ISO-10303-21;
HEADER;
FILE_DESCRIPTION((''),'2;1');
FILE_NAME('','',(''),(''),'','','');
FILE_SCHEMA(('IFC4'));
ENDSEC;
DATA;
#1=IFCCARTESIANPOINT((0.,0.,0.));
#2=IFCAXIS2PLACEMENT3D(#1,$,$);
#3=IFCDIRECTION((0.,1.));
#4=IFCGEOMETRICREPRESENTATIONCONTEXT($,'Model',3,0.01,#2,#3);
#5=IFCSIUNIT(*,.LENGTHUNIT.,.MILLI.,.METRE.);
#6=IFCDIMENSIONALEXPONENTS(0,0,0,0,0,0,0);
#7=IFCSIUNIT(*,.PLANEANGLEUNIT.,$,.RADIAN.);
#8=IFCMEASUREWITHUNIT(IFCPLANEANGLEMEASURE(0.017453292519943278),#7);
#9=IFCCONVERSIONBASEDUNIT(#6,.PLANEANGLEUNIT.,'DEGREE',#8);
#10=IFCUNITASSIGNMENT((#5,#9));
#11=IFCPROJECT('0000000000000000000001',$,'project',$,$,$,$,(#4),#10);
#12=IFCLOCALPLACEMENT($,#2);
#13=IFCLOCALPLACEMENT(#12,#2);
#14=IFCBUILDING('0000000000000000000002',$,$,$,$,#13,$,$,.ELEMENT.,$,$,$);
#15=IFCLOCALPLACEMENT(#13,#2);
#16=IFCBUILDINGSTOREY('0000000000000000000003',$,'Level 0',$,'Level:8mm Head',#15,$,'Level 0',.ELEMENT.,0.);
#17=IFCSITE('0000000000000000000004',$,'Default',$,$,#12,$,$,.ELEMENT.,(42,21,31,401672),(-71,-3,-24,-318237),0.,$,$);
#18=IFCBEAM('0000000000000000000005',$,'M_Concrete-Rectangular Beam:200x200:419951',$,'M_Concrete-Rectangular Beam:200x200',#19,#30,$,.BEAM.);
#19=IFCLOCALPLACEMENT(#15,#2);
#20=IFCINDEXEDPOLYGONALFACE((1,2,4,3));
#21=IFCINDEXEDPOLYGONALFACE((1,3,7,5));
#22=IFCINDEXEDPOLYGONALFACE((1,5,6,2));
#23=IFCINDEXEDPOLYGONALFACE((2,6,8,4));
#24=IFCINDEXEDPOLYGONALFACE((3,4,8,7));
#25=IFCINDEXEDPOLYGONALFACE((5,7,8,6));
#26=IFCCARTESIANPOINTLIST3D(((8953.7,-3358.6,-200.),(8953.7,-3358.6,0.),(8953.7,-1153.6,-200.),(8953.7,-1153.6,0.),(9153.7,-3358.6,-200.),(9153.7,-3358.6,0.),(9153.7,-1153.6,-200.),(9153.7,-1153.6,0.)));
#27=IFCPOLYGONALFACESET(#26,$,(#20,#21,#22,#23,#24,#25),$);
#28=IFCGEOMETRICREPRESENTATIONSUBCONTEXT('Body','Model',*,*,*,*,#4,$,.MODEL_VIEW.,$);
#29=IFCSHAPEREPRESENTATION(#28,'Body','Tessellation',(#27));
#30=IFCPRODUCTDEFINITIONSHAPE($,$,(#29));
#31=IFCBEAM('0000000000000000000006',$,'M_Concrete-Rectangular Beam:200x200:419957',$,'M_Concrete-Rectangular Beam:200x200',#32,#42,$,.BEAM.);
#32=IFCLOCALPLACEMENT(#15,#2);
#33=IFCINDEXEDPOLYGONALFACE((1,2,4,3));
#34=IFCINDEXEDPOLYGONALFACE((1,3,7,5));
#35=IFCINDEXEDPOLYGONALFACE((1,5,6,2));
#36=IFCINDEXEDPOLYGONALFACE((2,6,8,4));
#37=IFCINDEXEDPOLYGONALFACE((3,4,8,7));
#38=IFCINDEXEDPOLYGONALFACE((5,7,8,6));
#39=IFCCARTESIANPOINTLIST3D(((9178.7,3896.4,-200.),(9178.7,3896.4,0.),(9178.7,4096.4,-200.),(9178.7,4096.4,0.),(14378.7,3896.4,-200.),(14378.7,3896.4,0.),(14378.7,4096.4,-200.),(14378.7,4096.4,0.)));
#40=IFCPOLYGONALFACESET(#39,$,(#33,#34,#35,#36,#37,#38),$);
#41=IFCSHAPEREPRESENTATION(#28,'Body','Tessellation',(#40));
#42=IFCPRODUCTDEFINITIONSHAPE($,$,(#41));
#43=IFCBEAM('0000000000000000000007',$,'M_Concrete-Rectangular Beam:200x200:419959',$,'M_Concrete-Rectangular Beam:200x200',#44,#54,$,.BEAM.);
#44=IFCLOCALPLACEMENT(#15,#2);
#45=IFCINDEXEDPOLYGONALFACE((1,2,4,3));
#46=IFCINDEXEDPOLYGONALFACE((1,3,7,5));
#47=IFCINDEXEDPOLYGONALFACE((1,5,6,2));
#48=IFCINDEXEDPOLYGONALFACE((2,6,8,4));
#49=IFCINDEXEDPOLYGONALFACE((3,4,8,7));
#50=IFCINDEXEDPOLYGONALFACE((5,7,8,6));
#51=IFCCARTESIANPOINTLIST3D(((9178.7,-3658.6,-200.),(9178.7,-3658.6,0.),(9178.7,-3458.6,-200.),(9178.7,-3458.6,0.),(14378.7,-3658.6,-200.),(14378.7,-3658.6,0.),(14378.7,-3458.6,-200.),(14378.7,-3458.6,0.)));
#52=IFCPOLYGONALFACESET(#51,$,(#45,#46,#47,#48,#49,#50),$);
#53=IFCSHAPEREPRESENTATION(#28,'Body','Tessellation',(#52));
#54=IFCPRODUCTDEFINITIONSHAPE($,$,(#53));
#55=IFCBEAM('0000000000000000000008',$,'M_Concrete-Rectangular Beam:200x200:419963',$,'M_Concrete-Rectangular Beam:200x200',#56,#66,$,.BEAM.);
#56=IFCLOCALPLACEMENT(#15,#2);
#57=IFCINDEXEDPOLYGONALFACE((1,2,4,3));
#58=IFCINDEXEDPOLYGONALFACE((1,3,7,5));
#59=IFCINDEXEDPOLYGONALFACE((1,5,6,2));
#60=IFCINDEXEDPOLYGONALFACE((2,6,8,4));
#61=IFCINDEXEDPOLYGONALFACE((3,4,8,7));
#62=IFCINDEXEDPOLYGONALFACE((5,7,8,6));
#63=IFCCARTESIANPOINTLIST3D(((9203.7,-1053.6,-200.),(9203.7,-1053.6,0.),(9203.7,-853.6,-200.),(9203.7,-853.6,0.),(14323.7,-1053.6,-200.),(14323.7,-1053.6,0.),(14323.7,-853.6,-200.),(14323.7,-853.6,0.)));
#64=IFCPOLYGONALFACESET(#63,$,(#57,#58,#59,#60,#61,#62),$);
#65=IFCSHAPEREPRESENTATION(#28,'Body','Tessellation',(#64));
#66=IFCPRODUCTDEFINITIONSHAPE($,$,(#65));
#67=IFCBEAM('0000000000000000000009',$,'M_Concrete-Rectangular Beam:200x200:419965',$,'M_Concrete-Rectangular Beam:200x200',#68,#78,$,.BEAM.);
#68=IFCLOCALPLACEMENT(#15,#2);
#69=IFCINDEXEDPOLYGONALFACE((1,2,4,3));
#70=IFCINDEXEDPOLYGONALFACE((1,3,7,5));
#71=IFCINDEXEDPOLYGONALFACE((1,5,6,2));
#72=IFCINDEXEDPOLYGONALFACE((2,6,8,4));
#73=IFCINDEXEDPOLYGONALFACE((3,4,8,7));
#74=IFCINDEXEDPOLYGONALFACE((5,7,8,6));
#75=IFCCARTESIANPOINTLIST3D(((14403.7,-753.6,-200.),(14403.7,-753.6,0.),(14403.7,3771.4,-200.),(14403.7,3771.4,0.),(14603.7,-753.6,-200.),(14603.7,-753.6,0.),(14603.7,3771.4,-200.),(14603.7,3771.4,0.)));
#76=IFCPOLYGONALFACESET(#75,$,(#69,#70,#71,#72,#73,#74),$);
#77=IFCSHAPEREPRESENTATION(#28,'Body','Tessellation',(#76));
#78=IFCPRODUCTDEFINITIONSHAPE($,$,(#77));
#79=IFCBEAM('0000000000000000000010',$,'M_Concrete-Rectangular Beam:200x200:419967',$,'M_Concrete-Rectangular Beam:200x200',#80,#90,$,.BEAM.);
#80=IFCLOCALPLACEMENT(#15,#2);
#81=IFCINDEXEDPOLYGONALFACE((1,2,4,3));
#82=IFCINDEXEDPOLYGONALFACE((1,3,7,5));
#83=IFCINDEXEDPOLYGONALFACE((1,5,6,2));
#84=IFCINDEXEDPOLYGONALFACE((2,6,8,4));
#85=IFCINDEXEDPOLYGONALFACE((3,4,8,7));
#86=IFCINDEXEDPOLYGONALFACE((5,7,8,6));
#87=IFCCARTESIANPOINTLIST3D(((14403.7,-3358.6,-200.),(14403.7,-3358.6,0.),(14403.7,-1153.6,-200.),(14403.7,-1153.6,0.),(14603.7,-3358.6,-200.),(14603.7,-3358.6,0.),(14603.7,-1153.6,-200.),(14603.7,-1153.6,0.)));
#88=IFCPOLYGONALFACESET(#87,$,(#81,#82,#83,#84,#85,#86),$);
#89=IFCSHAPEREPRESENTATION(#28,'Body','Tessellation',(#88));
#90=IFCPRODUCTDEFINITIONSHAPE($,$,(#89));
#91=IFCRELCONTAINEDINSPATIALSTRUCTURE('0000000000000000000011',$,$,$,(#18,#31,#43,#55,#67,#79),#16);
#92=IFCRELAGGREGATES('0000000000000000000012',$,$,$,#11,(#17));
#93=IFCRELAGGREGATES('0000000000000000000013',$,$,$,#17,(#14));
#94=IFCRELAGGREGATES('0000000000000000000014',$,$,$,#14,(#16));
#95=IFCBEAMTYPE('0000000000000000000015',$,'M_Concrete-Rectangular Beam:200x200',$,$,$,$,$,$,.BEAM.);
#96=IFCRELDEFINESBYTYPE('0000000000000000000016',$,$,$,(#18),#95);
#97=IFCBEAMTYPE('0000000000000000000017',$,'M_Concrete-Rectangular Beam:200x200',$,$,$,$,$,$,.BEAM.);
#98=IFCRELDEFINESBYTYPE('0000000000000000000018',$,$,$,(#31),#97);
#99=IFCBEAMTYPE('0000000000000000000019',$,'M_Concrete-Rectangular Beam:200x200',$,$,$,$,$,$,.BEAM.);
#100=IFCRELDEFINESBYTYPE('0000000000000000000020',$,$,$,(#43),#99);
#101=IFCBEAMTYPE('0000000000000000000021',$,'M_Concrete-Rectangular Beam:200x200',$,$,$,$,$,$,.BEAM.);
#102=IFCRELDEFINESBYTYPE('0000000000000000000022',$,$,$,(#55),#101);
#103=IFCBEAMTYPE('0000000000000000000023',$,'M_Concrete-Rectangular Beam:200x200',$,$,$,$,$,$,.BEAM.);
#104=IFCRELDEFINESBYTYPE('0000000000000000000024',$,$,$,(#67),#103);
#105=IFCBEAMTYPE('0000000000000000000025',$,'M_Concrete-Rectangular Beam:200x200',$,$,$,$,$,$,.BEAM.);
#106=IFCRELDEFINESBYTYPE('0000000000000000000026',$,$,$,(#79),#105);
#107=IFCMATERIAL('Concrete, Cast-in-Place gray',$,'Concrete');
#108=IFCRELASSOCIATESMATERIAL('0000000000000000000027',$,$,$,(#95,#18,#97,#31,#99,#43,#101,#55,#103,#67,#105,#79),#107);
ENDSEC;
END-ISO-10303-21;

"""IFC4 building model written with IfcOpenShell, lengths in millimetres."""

from ifc_helpers import new_model, entity, si_unit, converted_unit, direction, frame, origin, place, context, subcontext, project, spatial, indexed_curve, outline, extrude, source, transform, mapped, material, type_object, type_shapes, element, save


model = new_model("IFC4")

# Units and contexts
model_context = context("Model", 3, precision=0.01, world=origin(), true_north=direction((0.0, 1.0)))
body_context = subcontext(model_context, "Body", "Model", "MODEL_VIEW")
ifc_project = project(units=[si_unit("LENGTHUNIT", "METRE", prefix="MILLI"), converted_unit("PLANEANGLEUNIT", "DEGREE", entity("IfcPlaneAngleMeasure", 0.017453292519943278), si_unit("PLANEANGLEUNIT", "RADIAN"), dimensions=[0, 0, 0, 0, 0, 0, 0])], contexts=[model_context])

# Site, building, storey
site_placement = place(None, origin())
site = spatial("IfcSite", under=ifc_project, at=site_placement, Name="Default", CompositionType="ELEMENT", RefLatitude=(42, 21, 31, 401672), RefLongitude=(-71, -3, -24, -318237), RefElevation=0.0)
building_placement = place(site_placement, origin())
building = spatial("IfcBuilding", under=site, at=building_placement, CompositionType="ELEMENT")
storey_placement = place(building_placement, origin())
storey = spatial("IfcBuildingStorey", under=building, at=storey_placement, Name="Level 0", ObjectType="Level:8mm Head", LongName="Level 0", CompositionType="ELEMENT", Elevation=0.0)

# Beams
ifc_material = material(Name="Concrete, Cast-in-Place gray", Category="Concrete")
beam_type_1 = type_object("IfcBeamType", Name="M_Concrete-Rectangular Beam:200x200", PredefinedType="BEAM", material=ifc_material)
shared_shape_1 = source(origin(), body_context, "Body", "SweptSolid", [
    extrude(outline(indexed_curve([(-100.0, -100.0), (100.0, -100.0), (100.0, 100.0), (-100.0, 100.0), (-100.0, -100.0)], self_intersect=False)), frame((9053.7, -1153.6, -100.0), z_axis=(0.0, -1.0, 0.0), x_axis=(-1.0, 0.0, 0.0)), (0.0, 0.0, 1.0), 2205.0),
])
type_shapes(beam_type_1, [shared_shape_1])
beam_1_placement = place(storey_placement, origin())
element("IfcBeam", 1, at=beam_1_placement, inside=storey, type_object=beam_type_1, material=ifc_material, Name="M_Concrete-Rectangular Beam:200x200:419951", ObjectType="M_Concrete-Rectangular Beam:200x200", PredefinedType="BEAM", context=body_context, shape_type="MappedRepresentation", body=[
    mapped(shared_shape_1, transform((0.0, 0.0, 0.0), scale=1.0)),
])
beam_type_2 = type_object("IfcBeamType", Name="M_Concrete-Rectangular Beam:200x200", PredefinedType="BEAM", material=ifc_material)
shared_shape_2 = source(origin(), body_context, "Body", "SweptSolid", [
    extrude(outline(indexed_curve([(-100.0, -100.0), (100.0, -100.0), (100.0, 100.0), (-100.0, 100.0), (-100.0, -100.0)], self_intersect=False)), frame((9178.7, 3996.4, -100.0), z_axis=(1.0, 0.0, 0.0), x_axis=(0.0, 0.0, -1.0)), (0.0, 0.0, 1.0), 5200.0),
])
type_shapes(beam_type_2, [shared_shape_2])
beam_2_placement = place(storey_placement, origin())
element("IfcBeam", 2, at=beam_2_placement, inside=storey, type_object=beam_type_2, material=ifc_material, Name="M_Concrete-Rectangular Beam:200x200:419957", ObjectType="M_Concrete-Rectangular Beam:200x200", PredefinedType="BEAM", context=body_context, shape_type="MappedRepresentation", body=[
    mapped(shared_shape_2, transform((0.0, 0.0, 0.0), scale=1.0)),
])
beam_type_3 = type_object("IfcBeamType", Name="M_Concrete-Rectangular Beam:200x200", PredefinedType="BEAM", material=ifc_material)
shared_shape_3 = source(origin(), body_context, "Body", "SweptSolid", [
    extrude(outline(indexed_curve([(-100.0, -100.0), (100.0, -100.0), (100.0, 100.0), (-100.0, 100.0), (-100.0, -100.0)], self_intersect=False)), frame((9178.7, -3558.6, -100.0), z_axis=(1.0, 0.0, 0.0), x_axis=(0.0, 0.0, -1.0)), (0.0, 0.0, 1.0), 5200.0),
])
type_shapes(beam_type_3, [shared_shape_3])
beam_3_placement = place(storey_placement, origin())
element("IfcBeam", 3, at=beam_3_placement, inside=storey, type_object=beam_type_3, material=ifc_material, Name="M_Concrete-Rectangular Beam:200x200:419959", ObjectType="M_Concrete-Rectangular Beam:200x200", PredefinedType="BEAM", context=body_context, shape_type="MappedRepresentation", body=[
    mapped(shared_shape_3, transform((0.0, 0.0, 0.0), scale=1.0)),
])
beam_type_4 = type_object("IfcBeamType", Name="M_Concrete-Rectangular Beam:200x200", PredefinedType="BEAM", material=ifc_material)
shared_shape_4 = source(origin(), body_context, "Body", "SweptSolid", [
    extrude(outline(indexed_curve([(-100.0, -100.0), (100.0, -100.0), (100.0, 100.0), (-100.0, 100.0), (-100.0, -100.0)], self_intersect=False)), frame((9203.7, -953.6, -100.0), z_axis=(1.0, 0.0, 0.0), x_axis=(0.0, 0.0, -1.0)), (0.0, 0.0, 1.0), 5120.0),
])
type_shapes(beam_type_4, [shared_shape_4])
beam_4_placement = place(storey_placement, origin())
element("IfcBeam", 4, at=beam_4_placement, inside=storey, type_object=beam_type_4, material=ifc_material, Name="M_Concrete-Rectangular Beam:200x200:419963", ObjectType="M_Concrete-Rectangular Beam:200x200", PredefinedType="BEAM", context=body_context, shape_type="MappedRepresentation", body=[
    mapped(shared_shape_4, transform((0.0, 0.0, 0.0), scale=1.0)),
])
beam_type_5 = type_object("IfcBeamType", Name="M_Concrete-Rectangular Beam:200x200", PredefinedType="BEAM", material=ifc_material)
shared_shape_5 = source(origin(), body_context, "Body", "SweptSolid", [
    extrude(outline(indexed_curve([(-100.0, -100.0), (100.0, -100.0), (100.0, 100.0), (-100.0, 100.0), (-100.0, -100.0)], self_intersect=False)), frame((14503.7, 3771.4, -100.0), z_axis=(0.0, -1.0, 0.0), x_axis=(-1.0, 0.0, 0.0)), (0.0, 0.0, 1.0), 4525.0),
])
type_shapes(beam_type_5, [shared_shape_5])
beam_5_placement = place(storey_placement, origin())
element("IfcBeam", 5, at=beam_5_placement, inside=storey, type_object=beam_type_5, material=ifc_material, Name="M_Concrete-Rectangular Beam:200x200:419965", ObjectType="M_Concrete-Rectangular Beam:200x200", PredefinedType="BEAM", context=body_context, shape_type="MappedRepresentation", body=[
    mapped(shared_shape_5, transform((0.0, 0.0, 0.0), scale=1.0)),
])
beam_type_6 = type_object("IfcBeamType", Name="M_Concrete-Rectangular Beam:200x200", PredefinedType="BEAM", material=ifc_material)
shared_shape_6 = source(origin(), body_context, "Body", "SweptSolid", [
    extrude(outline(indexed_curve([(-100.0, -100.0), (100.0, -100.0), (100.0, 100.0), (-100.0, 100.0), (-100.0, -100.0)], self_intersect=False)), frame((14503.7, -1153.6, -100.0), z_axis=(0.0, -1.0, 0.0), x_axis=(-1.0, 0.0, 0.0)), (0.0, 0.0, 1.0), 2205.0),
])
type_shapes(beam_type_6, [shared_shape_6])
beam_6_placement = place(storey_placement, origin())
element("IfcBeam", 6, at=beam_6_placement, inside=storey, type_object=beam_type_6, material=ifc_material, Name="M_Concrete-Rectangular Beam:200x200:419967", ObjectType="M_Concrete-Rectangular Beam:200x200", PredefinedType="BEAM", context=body_context, shape_type="MappedRepresentation", body=[
    mapped(shared_shape_6, transform((0.0, 0.0, 0.0), scale=1.0)),
])

save(model, "model.ifc")
